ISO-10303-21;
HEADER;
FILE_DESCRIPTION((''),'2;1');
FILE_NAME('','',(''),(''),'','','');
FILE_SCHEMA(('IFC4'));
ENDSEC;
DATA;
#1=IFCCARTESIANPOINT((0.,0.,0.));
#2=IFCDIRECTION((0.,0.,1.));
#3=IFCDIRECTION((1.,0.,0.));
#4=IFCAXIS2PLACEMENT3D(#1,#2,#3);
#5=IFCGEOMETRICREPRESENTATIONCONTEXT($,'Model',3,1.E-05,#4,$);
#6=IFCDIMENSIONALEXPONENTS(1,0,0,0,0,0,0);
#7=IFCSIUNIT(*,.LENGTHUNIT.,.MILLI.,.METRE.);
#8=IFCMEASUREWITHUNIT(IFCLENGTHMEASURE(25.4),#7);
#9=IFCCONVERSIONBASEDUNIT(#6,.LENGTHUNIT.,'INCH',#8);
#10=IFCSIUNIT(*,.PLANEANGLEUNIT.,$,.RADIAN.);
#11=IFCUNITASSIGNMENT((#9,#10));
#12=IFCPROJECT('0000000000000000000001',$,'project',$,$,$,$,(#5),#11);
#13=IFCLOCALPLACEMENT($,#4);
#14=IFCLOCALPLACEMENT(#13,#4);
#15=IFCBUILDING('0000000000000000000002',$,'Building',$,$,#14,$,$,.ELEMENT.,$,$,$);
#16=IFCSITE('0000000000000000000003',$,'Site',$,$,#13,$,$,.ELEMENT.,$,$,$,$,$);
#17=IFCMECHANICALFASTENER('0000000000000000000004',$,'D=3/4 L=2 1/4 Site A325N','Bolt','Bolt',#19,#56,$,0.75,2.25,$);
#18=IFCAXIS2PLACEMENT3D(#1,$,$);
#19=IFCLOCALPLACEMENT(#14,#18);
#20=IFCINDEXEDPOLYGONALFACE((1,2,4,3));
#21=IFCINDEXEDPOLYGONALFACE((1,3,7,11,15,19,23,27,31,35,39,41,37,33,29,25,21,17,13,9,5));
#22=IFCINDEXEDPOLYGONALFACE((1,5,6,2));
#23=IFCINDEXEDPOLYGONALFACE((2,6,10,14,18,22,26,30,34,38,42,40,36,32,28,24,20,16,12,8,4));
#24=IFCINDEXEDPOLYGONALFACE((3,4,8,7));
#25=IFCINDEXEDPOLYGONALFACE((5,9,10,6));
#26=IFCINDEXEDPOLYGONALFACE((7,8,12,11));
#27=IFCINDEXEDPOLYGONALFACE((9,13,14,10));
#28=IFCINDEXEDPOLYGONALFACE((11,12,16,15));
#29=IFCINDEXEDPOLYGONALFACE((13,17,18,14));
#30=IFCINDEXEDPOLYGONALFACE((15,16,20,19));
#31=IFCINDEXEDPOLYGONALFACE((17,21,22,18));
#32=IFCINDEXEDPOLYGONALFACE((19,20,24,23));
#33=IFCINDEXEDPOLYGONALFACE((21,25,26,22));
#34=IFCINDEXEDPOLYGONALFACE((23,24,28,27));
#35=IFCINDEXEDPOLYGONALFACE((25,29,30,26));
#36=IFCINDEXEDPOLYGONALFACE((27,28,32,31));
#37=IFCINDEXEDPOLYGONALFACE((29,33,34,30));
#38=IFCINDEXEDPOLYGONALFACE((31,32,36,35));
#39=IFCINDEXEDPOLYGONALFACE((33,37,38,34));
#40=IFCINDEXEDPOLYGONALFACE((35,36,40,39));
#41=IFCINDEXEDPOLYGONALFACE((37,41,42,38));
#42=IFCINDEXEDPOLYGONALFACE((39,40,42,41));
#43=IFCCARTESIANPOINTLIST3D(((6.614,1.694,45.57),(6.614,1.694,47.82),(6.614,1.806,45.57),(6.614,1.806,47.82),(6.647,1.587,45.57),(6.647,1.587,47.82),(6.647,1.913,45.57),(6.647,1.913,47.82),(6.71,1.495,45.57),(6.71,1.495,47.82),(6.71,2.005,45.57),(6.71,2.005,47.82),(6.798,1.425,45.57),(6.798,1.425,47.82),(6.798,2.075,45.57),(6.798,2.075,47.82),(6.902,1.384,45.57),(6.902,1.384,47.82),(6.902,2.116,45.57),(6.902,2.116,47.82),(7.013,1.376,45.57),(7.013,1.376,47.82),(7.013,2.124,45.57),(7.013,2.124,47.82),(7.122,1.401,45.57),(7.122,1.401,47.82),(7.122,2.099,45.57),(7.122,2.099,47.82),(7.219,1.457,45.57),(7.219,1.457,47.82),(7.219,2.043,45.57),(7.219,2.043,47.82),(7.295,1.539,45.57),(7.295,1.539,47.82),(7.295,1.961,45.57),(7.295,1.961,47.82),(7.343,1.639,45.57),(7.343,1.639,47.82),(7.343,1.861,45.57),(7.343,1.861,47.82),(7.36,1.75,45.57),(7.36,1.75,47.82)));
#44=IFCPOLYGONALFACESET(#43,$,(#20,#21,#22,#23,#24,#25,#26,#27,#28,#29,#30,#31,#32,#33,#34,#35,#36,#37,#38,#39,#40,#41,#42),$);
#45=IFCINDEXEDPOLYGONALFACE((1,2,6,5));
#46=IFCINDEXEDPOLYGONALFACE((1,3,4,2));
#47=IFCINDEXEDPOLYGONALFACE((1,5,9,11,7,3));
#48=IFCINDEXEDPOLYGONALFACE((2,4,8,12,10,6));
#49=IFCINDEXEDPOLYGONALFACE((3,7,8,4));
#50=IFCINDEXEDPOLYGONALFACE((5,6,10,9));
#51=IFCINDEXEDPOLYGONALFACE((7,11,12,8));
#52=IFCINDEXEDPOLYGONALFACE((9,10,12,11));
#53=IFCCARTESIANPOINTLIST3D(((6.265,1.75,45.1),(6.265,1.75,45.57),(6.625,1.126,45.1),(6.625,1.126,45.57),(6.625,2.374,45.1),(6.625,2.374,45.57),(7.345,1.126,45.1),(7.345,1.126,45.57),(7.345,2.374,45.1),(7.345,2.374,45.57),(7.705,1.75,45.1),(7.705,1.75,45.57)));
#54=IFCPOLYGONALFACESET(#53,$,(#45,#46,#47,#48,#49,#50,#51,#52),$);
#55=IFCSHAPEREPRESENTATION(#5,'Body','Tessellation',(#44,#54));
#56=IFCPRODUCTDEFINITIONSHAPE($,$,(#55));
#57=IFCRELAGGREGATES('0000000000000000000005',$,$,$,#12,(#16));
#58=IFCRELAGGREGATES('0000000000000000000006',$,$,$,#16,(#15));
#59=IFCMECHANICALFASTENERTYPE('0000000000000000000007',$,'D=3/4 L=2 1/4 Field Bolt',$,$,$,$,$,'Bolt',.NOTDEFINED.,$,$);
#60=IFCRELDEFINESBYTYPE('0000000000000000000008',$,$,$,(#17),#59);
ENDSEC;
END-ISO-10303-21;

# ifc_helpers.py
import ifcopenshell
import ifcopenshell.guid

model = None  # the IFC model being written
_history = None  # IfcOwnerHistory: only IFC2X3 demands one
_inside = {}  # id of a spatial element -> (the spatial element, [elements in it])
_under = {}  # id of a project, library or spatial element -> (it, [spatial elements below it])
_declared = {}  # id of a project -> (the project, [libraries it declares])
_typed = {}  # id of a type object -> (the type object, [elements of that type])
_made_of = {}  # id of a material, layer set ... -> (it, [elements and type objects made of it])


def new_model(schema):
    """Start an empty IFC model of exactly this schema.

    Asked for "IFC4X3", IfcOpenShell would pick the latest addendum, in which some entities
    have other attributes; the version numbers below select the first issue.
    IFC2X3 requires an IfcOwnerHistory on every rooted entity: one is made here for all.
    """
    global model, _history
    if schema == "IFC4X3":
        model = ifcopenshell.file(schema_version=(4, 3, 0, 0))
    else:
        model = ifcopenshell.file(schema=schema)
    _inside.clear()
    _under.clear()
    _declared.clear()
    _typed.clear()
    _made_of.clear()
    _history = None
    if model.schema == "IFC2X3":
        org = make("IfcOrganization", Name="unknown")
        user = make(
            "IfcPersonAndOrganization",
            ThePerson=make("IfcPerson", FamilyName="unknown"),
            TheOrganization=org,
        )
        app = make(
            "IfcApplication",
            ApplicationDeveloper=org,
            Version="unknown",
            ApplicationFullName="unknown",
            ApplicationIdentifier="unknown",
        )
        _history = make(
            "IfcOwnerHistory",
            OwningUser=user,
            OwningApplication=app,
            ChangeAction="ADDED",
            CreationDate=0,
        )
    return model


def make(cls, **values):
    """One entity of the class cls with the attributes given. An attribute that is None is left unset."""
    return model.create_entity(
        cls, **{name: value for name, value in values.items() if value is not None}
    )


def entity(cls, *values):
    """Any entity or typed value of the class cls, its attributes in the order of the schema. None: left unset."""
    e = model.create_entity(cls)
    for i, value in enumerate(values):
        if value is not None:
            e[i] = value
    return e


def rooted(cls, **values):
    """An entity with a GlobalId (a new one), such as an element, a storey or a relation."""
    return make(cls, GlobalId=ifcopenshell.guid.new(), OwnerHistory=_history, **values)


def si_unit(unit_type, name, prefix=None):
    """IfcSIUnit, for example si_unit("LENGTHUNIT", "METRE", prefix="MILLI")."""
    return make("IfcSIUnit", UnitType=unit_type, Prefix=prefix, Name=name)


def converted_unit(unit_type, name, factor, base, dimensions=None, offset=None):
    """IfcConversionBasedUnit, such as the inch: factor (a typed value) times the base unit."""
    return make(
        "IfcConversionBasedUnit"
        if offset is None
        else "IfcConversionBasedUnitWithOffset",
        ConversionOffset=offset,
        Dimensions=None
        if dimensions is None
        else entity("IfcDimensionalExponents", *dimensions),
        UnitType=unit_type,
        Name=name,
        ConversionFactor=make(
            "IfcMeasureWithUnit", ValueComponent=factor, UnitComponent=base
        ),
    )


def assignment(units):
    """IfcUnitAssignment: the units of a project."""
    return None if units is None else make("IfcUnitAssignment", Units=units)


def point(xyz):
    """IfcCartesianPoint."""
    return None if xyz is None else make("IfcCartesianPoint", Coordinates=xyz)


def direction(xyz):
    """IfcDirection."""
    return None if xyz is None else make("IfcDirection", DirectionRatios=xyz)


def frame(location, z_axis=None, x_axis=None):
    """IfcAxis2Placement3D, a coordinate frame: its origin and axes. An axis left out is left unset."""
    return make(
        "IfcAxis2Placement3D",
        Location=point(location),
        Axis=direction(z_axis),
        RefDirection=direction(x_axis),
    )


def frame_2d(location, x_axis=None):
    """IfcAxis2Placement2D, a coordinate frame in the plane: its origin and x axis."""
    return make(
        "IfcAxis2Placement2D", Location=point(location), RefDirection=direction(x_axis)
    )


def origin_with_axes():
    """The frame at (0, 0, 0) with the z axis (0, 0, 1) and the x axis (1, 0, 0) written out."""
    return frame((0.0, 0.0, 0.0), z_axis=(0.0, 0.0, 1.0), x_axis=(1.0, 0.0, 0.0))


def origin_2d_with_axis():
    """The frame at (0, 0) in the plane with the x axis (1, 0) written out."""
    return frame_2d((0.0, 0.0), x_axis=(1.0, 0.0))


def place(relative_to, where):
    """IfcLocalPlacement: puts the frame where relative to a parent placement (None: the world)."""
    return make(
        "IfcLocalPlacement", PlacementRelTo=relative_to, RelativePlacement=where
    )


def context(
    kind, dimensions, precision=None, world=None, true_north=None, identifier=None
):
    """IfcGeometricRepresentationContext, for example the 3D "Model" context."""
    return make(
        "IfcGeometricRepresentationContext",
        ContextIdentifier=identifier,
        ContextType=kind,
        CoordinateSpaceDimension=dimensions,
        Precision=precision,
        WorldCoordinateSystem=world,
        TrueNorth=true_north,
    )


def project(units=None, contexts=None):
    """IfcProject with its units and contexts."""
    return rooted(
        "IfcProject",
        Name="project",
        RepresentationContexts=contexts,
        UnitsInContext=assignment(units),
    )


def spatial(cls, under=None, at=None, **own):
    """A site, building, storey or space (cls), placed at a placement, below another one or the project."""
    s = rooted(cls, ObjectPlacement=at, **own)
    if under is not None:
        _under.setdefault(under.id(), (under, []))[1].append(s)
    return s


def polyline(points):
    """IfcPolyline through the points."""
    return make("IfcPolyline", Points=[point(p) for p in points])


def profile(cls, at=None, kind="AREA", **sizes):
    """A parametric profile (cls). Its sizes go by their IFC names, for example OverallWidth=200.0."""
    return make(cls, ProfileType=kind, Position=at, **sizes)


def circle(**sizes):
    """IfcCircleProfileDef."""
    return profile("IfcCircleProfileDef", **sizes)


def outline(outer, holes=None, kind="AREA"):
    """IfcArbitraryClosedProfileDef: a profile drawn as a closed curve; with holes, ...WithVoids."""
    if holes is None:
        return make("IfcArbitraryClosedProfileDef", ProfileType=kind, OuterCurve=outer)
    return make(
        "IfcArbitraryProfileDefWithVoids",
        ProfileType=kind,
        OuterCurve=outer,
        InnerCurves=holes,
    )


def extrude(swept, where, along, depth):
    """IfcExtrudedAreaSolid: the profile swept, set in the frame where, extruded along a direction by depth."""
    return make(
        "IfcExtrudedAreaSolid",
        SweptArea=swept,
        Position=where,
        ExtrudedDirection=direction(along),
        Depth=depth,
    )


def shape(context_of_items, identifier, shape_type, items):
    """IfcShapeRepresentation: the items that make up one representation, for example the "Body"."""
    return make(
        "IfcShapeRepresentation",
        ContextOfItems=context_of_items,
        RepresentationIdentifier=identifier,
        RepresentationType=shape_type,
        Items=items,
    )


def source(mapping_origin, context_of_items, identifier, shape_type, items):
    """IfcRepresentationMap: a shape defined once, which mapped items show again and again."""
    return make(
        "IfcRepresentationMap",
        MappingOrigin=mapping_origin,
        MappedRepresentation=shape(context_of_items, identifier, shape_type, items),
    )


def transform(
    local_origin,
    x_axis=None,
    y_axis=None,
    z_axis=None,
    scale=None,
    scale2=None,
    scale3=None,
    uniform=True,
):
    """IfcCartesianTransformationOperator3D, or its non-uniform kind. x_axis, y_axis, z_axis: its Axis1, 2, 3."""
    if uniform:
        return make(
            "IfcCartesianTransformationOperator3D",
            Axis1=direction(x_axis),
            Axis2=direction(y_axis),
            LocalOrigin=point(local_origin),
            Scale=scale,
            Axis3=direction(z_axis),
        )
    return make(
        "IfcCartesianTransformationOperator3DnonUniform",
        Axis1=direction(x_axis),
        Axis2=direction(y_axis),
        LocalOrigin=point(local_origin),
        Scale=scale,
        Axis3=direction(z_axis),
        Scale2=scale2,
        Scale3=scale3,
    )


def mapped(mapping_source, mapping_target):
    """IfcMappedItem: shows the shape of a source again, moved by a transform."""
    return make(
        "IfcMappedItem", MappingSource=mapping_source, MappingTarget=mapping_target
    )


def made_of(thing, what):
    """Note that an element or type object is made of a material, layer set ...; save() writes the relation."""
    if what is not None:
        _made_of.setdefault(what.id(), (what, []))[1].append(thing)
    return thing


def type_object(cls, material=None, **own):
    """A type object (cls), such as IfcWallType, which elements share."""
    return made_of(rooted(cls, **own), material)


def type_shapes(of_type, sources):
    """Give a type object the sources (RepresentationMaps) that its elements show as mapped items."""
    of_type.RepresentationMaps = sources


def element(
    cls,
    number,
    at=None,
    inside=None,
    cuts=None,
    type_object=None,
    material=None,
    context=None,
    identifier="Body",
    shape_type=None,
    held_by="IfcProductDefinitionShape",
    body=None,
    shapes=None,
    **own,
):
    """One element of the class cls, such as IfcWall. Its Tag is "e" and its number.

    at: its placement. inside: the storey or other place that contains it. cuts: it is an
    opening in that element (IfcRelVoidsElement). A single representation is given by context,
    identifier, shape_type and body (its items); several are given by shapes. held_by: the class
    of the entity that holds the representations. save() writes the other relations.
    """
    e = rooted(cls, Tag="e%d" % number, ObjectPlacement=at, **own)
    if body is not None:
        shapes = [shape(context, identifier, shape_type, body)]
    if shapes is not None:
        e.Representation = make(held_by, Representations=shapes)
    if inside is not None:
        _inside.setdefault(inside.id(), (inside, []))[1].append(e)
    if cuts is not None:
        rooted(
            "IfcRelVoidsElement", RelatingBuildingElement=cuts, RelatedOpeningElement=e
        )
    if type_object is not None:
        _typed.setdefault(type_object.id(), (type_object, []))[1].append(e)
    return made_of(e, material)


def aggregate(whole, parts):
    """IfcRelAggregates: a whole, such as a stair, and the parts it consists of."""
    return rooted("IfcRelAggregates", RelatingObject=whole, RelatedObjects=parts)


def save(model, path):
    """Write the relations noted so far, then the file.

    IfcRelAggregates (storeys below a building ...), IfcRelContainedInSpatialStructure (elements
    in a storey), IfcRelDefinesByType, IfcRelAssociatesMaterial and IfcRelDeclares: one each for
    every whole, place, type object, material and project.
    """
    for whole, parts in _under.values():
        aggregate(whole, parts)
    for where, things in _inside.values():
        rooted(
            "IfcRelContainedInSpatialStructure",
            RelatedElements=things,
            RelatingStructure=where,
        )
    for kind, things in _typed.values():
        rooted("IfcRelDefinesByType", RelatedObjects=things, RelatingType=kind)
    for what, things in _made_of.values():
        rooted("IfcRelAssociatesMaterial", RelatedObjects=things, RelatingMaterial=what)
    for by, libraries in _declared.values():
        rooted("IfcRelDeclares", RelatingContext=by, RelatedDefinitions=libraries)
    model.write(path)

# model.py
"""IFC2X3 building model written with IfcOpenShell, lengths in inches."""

from ifc_helpers import new_model, entity, si_unit, converted_unit, frame, origin_with_axes, origin_2d_with_axis, place, context, project, spatial, polyline, circle, outline, extrude, source, transform, mapped, type_object, type_shapes, element, save


model = new_model("IFC2X3")

# Units and contexts
model_context = context("Model", 3, precision=1e-05, world=origin_with_axes())
ifc_project = project(units=[converted_unit("LENGTHUNIT", "INCH", entity("IfcLengthMeasure", 25.4), si_unit("LENGTHUNIT", "METRE", prefix="MILLI"), dimensions=[1, 0, 0, 0, 0, 0, 0]), si_unit("PLANEANGLEUNIT", "RADIAN")], contexts=[model_context])

# Site, building
site_placement = place(None, origin_with_axes())
site = spatial("IfcSite", under=ifc_project, at=site_placement, Name="Site", CompositionType="ELEMENT")
building_placement = place(site_placement, origin_with_axes())
building = spatial("IfcBuilding", under=site, at=building_placement, Name="Building", CompositionType="ELEMENT")

# Mechanical fastener
placement_1 = place(building_placement, frame((0.0, 0.0, 46.0), z_axis=(0.0, 0.0, 1.0), x_axis=(1.0, 0.0, 0.0)))
mechanical_fastener_type_1 = type_object("IfcMechanicalFastenerType", Name="D=3/4 L=2 1/4 Field Bolt", ElementType="Bolt")
shared_shape_1 = source(origin_with_axes(), model_context, "Body", "SweptSolid", [
    extrude(circle(Radius=0.375, at=origin_2d_with_axis()), frame((0.0, 0.0, 0.0), z_axis=(1.0, 0.0, 0.0), x_axis=(0.0, 1.0, 0.0)), (0.0, 0.0, 1.0), 2.25),
    extrude(outline(polyline([(-0.72, 0.0), (-0.36, 0.624), (0.36, 0.624), (0.72, 0.0), (0.36, -0.624), (-0.36, -0.624), (-0.72, 0.0)])), frame((0.0, 0.0, 0.0), z_axis=(1.0, 0.0, 0.0), x_axis=(0.0, 1.0, 0.0)), (0.0, 0.0, -1.0), 0.47),
])
type_shapes(mechanical_fastener_type_1, [shared_shape_1])
placement_2 = place(placement_1, frame((6.985, 1.75, -0.43), z_axis=(0.0, 1.0, 0.0), x_axis=(0.0, 0.0, 1.0)))
for number, where, z_axis, x_axis, name in (
    (1, (0.0, 0.0, 0.0), (0.0, 0.0, 1.0), (1.0, 0.0, 0.0), "D=3/4 L=2 1/4 Site A325N"),
):
    element("IfcMechanicalFastener", number, at=place(placement_2, frame(where, z_axis=z_axis, x_axis=x_axis)), type_object=mechanical_fastener_type_1, Name=name, Description="Bolt", ObjectType="Bolt", NominalDiameter=0.75, NominalLength=2.25, context=model_context, shape_type="MappedRepresentation", body=[
        mapped(shared_shape_1, transform((0.0, 0.0, 0.0), scale=1.0)),
    ])

save(model, "model.ifc")
